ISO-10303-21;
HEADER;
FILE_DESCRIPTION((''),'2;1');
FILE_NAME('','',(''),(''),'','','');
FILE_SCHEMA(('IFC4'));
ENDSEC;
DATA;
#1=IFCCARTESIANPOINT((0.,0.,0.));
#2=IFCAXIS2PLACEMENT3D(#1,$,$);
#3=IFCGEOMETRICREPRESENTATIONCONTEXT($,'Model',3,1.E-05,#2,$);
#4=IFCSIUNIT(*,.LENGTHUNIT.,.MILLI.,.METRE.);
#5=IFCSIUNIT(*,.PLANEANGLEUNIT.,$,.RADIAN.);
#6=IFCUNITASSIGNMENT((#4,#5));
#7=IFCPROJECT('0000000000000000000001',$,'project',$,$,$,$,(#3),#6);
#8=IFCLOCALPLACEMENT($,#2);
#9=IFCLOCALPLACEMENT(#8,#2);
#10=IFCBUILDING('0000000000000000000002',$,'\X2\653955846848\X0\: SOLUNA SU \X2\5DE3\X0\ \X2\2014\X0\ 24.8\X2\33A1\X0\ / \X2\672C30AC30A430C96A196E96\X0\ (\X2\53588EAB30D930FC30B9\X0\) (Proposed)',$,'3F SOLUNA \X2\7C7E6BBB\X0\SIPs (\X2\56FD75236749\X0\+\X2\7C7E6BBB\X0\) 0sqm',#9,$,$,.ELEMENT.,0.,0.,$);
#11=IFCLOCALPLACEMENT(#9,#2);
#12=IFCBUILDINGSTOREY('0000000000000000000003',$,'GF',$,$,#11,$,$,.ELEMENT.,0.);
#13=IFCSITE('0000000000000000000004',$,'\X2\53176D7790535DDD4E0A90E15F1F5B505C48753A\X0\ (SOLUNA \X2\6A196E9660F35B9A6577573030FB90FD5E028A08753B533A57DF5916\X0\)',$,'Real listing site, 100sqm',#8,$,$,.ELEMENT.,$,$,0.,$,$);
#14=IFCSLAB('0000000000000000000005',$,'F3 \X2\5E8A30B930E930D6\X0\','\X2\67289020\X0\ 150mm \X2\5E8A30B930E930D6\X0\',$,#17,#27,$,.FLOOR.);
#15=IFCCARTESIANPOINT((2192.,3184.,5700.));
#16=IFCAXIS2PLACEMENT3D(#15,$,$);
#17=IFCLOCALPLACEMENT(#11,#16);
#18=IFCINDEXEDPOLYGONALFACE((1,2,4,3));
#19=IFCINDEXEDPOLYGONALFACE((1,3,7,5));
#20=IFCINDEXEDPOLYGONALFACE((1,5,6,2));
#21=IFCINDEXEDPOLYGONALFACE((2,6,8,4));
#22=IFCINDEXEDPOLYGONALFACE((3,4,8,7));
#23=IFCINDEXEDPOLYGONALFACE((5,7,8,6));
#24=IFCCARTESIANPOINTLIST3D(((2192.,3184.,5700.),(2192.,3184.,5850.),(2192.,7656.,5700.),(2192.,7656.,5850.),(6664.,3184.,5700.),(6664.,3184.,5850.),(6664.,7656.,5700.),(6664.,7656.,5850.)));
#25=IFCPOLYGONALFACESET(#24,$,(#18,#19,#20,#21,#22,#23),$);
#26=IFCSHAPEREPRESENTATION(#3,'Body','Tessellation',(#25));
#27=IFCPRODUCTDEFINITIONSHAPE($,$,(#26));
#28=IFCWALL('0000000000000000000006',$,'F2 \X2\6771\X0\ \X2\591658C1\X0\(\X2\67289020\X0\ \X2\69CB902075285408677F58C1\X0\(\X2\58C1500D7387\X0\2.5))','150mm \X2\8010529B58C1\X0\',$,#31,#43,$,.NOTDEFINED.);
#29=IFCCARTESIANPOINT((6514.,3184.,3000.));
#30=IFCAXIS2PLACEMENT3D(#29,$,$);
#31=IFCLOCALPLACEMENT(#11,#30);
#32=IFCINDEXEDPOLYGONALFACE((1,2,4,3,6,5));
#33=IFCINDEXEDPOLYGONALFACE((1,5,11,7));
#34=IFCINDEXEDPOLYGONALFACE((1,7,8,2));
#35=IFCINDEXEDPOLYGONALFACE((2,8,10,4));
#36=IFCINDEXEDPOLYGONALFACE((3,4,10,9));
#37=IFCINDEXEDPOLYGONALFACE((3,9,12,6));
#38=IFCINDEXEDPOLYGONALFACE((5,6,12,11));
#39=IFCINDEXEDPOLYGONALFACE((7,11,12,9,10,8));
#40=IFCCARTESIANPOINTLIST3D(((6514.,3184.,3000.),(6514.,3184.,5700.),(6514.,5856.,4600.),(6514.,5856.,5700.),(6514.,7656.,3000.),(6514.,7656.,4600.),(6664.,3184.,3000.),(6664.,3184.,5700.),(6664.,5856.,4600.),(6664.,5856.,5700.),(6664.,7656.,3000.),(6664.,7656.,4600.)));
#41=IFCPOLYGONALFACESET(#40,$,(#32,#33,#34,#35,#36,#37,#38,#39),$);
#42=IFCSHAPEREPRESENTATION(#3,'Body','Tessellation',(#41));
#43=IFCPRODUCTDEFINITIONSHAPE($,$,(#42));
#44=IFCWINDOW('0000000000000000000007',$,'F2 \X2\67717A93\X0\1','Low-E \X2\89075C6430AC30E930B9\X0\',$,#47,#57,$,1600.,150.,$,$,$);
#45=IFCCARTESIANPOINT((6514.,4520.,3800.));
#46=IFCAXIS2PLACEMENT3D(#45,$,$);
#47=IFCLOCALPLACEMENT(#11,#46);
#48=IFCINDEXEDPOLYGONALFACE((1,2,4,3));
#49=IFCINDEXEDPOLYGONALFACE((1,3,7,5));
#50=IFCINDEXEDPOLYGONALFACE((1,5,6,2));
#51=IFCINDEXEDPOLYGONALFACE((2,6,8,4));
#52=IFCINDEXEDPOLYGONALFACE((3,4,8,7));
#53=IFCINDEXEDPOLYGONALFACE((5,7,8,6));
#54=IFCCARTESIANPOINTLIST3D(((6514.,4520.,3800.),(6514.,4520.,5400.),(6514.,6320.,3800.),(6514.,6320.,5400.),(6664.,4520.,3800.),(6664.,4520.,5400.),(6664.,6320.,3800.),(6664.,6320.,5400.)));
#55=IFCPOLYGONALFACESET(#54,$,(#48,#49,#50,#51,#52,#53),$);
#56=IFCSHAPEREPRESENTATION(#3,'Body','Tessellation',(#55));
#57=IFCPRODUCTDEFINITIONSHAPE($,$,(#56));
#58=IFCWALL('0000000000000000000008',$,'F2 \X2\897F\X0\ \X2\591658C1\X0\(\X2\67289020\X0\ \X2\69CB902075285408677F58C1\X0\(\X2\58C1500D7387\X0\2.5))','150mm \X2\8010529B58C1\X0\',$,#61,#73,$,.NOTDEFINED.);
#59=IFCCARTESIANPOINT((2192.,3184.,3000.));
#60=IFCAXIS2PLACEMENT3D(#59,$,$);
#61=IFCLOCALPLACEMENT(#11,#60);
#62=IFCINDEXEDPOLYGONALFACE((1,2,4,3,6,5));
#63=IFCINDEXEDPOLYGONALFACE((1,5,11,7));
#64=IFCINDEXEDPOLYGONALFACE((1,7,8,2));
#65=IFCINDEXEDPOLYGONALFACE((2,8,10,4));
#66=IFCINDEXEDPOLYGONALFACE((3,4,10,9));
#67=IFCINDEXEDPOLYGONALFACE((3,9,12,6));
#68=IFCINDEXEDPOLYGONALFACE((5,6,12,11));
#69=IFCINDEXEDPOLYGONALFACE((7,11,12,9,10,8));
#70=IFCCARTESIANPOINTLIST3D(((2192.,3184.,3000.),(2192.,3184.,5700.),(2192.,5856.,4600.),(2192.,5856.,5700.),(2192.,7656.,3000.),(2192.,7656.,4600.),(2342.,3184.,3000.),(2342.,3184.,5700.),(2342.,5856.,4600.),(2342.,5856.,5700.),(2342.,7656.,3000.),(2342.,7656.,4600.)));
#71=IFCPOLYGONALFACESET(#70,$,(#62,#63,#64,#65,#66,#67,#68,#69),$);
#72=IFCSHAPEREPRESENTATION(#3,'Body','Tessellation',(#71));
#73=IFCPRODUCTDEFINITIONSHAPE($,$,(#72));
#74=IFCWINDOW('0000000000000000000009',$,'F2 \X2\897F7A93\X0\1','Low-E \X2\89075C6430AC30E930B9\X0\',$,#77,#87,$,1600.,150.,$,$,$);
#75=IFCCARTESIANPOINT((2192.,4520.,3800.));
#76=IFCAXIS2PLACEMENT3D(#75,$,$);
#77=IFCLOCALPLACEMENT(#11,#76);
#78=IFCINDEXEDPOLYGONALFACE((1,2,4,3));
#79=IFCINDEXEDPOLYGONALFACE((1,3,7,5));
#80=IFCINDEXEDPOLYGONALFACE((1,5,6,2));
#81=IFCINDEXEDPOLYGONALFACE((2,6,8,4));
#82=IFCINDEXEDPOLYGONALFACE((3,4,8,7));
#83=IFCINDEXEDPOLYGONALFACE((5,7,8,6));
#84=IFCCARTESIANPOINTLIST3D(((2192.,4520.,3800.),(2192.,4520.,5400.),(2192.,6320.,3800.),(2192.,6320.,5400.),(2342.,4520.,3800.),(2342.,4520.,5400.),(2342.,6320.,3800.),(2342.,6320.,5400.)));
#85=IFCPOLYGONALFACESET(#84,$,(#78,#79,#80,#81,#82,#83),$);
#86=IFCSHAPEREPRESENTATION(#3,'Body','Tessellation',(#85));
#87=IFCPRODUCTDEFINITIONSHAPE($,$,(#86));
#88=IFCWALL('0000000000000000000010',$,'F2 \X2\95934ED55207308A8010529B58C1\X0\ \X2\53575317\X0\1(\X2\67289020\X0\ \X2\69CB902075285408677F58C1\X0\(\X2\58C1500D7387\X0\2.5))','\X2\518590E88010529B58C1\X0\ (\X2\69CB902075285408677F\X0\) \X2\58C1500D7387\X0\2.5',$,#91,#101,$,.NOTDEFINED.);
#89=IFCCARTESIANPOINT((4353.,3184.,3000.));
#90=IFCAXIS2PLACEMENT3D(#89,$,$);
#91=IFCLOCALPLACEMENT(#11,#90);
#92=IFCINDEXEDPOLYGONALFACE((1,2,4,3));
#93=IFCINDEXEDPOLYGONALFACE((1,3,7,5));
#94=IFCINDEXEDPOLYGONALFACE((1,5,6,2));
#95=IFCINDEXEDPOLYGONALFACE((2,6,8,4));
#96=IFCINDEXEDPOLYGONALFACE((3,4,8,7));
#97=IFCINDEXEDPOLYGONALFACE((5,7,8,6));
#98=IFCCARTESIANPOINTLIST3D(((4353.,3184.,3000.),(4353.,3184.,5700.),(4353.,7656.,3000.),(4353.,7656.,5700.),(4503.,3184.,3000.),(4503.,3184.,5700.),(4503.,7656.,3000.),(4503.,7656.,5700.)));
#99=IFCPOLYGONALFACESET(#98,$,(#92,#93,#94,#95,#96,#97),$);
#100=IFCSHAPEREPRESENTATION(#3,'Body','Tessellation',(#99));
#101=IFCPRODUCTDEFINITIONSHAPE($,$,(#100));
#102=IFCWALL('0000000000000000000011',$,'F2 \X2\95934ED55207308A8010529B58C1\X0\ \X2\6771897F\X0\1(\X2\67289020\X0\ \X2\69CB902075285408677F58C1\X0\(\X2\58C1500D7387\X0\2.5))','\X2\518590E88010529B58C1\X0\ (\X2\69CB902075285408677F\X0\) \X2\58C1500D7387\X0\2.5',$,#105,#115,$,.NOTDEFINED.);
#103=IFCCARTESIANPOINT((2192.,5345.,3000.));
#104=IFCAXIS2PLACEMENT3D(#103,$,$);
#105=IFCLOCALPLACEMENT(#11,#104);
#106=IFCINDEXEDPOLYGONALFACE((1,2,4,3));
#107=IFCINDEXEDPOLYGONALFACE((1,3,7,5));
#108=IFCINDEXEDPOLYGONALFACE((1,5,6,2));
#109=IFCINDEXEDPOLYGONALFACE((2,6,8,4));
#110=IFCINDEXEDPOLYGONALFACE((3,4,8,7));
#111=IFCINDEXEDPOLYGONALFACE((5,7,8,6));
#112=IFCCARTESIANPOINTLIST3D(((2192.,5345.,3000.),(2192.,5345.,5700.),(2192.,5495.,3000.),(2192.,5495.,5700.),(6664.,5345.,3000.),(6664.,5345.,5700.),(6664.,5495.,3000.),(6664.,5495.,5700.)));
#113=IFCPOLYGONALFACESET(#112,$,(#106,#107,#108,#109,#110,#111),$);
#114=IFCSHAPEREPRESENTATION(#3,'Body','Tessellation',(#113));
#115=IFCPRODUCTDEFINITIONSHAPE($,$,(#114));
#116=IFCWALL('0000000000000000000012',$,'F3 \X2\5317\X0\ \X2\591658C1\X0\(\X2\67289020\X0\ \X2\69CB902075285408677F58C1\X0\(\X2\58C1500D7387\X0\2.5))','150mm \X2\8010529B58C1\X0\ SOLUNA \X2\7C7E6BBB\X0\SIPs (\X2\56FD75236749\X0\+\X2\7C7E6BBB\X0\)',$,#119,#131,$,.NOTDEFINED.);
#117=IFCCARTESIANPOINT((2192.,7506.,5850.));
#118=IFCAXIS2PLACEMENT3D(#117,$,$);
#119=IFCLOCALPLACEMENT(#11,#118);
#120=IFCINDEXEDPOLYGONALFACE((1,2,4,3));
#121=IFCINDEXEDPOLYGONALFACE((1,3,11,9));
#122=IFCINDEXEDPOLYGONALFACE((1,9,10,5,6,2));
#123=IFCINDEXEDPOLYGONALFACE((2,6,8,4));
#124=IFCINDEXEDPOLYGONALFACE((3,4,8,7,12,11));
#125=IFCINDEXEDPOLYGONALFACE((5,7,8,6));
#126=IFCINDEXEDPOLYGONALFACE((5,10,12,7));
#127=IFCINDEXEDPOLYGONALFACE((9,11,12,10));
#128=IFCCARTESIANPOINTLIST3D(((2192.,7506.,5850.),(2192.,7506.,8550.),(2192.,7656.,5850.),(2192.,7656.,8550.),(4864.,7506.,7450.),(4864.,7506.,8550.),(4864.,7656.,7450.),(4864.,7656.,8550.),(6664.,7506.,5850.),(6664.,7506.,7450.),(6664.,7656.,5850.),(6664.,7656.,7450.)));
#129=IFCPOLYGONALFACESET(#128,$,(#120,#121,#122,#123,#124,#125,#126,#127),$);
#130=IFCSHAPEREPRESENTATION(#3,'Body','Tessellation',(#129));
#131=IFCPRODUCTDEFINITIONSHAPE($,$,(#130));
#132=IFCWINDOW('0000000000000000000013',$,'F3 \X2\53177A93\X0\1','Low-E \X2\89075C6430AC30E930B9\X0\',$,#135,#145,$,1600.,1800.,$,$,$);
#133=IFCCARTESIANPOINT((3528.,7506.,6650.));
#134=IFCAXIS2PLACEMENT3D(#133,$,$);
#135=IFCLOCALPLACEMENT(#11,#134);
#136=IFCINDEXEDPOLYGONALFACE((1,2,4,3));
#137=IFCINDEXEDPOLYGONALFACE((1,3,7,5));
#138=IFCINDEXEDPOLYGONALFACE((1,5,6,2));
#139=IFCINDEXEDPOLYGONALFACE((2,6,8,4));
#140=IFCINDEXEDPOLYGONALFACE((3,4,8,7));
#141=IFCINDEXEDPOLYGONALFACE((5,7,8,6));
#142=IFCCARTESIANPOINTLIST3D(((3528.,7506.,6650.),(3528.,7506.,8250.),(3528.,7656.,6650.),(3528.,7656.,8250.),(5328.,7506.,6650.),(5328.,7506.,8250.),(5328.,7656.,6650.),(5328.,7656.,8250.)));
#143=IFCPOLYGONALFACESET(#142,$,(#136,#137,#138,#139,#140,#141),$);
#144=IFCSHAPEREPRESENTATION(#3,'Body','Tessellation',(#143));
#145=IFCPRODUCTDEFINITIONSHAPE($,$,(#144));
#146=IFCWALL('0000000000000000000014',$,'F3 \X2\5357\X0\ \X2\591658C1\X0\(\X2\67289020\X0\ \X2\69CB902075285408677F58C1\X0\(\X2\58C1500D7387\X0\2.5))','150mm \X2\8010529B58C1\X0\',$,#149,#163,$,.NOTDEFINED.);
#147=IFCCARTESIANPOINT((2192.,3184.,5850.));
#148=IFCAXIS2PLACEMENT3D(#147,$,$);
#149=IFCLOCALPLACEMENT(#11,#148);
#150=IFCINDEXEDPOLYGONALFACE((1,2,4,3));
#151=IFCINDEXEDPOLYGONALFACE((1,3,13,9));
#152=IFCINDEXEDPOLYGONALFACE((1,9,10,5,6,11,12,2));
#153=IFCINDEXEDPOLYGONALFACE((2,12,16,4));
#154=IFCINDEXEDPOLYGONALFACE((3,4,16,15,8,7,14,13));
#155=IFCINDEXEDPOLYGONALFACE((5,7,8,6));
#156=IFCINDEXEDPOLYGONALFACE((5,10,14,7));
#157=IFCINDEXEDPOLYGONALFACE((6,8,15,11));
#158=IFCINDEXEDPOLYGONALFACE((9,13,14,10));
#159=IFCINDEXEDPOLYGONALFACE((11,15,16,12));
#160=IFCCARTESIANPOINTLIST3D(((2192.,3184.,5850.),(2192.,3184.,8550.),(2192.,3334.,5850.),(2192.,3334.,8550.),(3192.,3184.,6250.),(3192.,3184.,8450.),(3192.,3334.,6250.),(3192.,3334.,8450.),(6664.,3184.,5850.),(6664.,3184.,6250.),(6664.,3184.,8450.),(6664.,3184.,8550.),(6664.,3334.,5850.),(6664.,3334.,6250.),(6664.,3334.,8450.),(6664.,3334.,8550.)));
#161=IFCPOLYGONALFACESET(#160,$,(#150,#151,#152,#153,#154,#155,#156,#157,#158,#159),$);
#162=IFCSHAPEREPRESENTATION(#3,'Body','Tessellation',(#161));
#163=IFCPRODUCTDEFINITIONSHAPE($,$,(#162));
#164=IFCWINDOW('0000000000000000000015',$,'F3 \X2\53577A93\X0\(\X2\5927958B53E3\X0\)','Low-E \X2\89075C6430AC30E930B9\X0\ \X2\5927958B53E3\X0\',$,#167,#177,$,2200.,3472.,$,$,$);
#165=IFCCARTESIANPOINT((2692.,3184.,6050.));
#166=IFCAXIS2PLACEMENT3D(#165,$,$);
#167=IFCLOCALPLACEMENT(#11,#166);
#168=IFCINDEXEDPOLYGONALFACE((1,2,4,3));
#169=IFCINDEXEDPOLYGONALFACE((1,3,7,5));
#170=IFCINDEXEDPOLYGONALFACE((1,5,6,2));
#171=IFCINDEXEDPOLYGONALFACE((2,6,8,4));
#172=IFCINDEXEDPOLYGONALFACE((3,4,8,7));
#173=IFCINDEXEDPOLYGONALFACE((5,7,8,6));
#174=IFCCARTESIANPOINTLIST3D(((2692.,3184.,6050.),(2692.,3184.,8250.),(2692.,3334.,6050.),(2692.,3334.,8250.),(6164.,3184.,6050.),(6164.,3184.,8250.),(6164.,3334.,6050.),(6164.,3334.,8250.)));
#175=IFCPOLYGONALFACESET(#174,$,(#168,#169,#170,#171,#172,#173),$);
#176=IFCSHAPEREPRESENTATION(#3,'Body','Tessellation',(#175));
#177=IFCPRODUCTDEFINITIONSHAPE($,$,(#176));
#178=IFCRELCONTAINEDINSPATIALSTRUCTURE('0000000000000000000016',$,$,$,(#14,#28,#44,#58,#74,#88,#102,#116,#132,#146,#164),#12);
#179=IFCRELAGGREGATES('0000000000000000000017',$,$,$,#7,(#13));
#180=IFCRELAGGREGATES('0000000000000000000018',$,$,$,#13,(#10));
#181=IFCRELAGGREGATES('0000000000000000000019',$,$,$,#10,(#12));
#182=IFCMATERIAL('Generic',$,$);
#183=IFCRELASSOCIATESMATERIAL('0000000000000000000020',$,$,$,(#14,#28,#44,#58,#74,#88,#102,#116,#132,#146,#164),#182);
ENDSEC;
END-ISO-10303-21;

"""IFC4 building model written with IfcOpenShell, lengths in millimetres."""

from ifc_helpers import new_model, si_unit, frame, frame_2d, origin, place, context, project, spatial, rectangle, extrude, material, element, fill, save


model = new_model("IFC4")

# Units and contexts
model_context = context("Model", 3, precision=1e-05, world=origin())
ifc_project = project(units=[si_unit("LENGTHUNIT", "METRE", prefix="MILLI"), si_unit("PLANEANGLEUNIT", "RADIAN")], contexts=[model_context])

# Site, building, storey
site_placement = place(None, origin())
site = spatial("IfcSite", under=ifc_project, at=site_placement, Name="北海道川上郡弟子屈町 (SOLUNA 標準想定敷地・都市計画区域外)", ObjectType="Real listing site, 100sqm", CompositionType="ELEMENT", RefElevation=0.0)
building_placement = place(site_placement, origin())
building = spatial("IfcBuilding", under=site, at=building_placement, Name="改善案: SOLUNA SU 巣 — 24.8㎡ / 本ガイド標準 (単身ベース) (Proposed)", ObjectType="3F SOLUNA 籾殻SIPs (国産杉+籾殻) 0sqm", CompositionType="ELEMENT", ElevationOfRefHeight=0.0, ElevationOfTerrain=0.0)
storey_placement = place(building_placement, origin())
storey = spatial("IfcBuildingStorey", under=building, at=storey_placement, Name="GF", CompositionType="ELEMENT", Elevation=0.0)

# Slab
ifc_material_1 = material(Name="Generic")
slab_placement = place(storey_placement, frame((2192.0, 3184.0, 5700.0)))
element("IfcSlab", 1, at=slab_placement, inside=storey, material=ifc_material_1, Name="F3 床スラブ", Description="木造 150mm 床スラブ", PredefinedType="FLOOR", context=model_context, shape_type="SweptSolid", body=[
    extrude(rectangle(XDim=4472.0, YDim=4472.0, at=frame_2d((2236.0, 2236.0))), frame((2192.0, 3184.0, 5700.0)), (0.0, 0.0, 1.0), 150.0),
])

# Walls, openings, windows
wall_1_placement = place(storey_placement, frame((6514.0, 3184.0, 3000.0)))
wall_1 = element("IfcWall", 2, at=wall_1_placement, inside=storey, material=ifc_material_1, Name="F2 東 外壁(木造 構造用合板壁(壁倍率2.5))", Description="150mm 耐力壁", PredefinedType="NOTDEFINED", context=model_context, shape_type="SweptSolid", body=[
    extrude(rectangle(XDim=150.0, YDim=4472.0, at=frame_2d((75.0, 2236.0))), frame((6514.0, 3184.0, 3000.0)), (0.0, 0.0, 1.0), 2700.0),
])
opening_1_placement = place(storey_placement, frame((6514.0, 4520.0, 3800.0)))
opening_1 = element("IfcOpeningElement", 3, at=opening_1_placement, cuts=wall_1, PredefinedType="NOTDEFINED", context=model_context, shape_type="SweptSolid", body=[
    extrude(rectangle(XDim=150.0, YDim=1800.0, at=frame_2d((75.0, 900.0))), frame((6514.0, 4520.0, 3800.0)), (0.0, 0.0, 1.0), 1600.0),
])
window_1_placement = place(storey_placement, frame((6514.0, 4520.0, 3800.0)))
window_1 = element("IfcWindow", 4, at=window_1_placement, inside=storey, material=ifc_material_1, Name="F2 東窓1", Description="Low-E 複層ガラス", OverallHeight=1600.0, OverallWidth=150.0, context=model_context, shape_type="SweptSolid", body=[
    extrude(rectangle(XDim=150.0, YDim=1800.0, at=frame_2d((75.0, 900.0))), frame((6514.0, 4520.0, 3800.0)), (0.0, 0.0, 1.0), 1600.0),
])
fill(opening_1, window_1)
wall_2_placement = place(storey_placement, frame((2192.0, 3184.0, 3000.0)))
wall_2 = element("IfcWall", 5, at=wall_2_placement, inside=storey, material=ifc_material_1, Name="F2 西 外壁(木造 構造用合板壁(壁倍率2.5))", Description="150mm 耐力壁", PredefinedType="NOTDEFINED", context=model_context, shape_type="SweptSolid", body=[
    extrude(rectangle(XDim=150.0, YDim=4472.0, at=frame_2d((75.0, 2236.0))), frame((2192.0, 3184.0, 3000.0)), (0.0, 0.0, 1.0), 2700.0),
])
opening_2_placement = place(storey_placement, frame((2192.0, 4520.0, 3800.0)))
opening_2 = element("IfcOpeningElement", 6, at=opening_2_placement, cuts=wall_2, PredefinedType="NOTDEFINED", context=model_context, shape_type="SweptSolid", body=[
    extrude(rectangle(XDim=150.0, YDim=1800.0, at=frame_2d((75.0, 900.0))), frame((2192.0, 4520.0, 3800.0)), (0.0, 0.0, 1.0), 1600.0),
])
window_2_placement = place(storey_placement, frame((2192.0, 4520.0, 3800.0)))
window_2 = element("IfcWindow", 7, at=window_2_placement, inside=storey, material=ifc_material_1, Name="F2 西窓1", Description="Low-E 複層ガラス", OverallHeight=1600.0, OverallWidth=150.0, context=model_context, shape_type="SweptSolid", body=[
    extrude(rectangle(XDim=150.0, YDim=1800.0, at=frame_2d((75.0, 900.0))), frame((2192.0, 4520.0, 3800.0)), (0.0, 0.0, 1.0), 1600.0),
])
fill(opening_2, window_2)

# Walls
wall_3_placement = place(storey_placement, frame((4353.0, 3184.0, 3000.0)))
element("IfcWall", 8, at=wall_3_placement, inside=storey, material=ifc_material_1, Name="F2 間仕切り耐力壁 南北1(木造 構造用合板壁(壁倍率2.5))", Description="内部耐力壁 (構造用合板) 壁倍率2.5", PredefinedType="NOTDEFINED", context=model_context, shape_type="SweptSolid", body=[
    extrude(rectangle(XDim=150.0, YDim=4472.0, at=frame_2d((75.0, 2236.0))), frame((4353.0, 3184.0, 3000.0)), (0.0, 0.0, 1.0), 2700.0),
])
wall_4_placement = place(storey_placement, frame((2192.0, 5345.0, 3000.0)))
element("IfcWall", 9, at=wall_4_placement, inside=storey, material=ifc_material_1, Name="F2 間仕切り耐力壁 東西1(木造 構造用合板壁(壁倍率2.5))", Description="内部耐力壁 (構造用合板) 壁倍率2.5", PredefinedType="NOTDEFINED", context=model_context, shape_type="SweptSolid", body=[
    extrude(rectangle(XDim=4472.0, YDim=150.0, at=frame_2d((2236.0, 75.0))), frame((2192.0, 5345.0, 3000.0)), (0.0, 0.0, 1.0), 2700.0),
])

# Walls, openings, windows
wall_5_placement = place(storey_placement, frame((2192.0, 7506.0, 5850.0)))
wall_5 = element("IfcWall", 10, at=wall_5_placement, inside=storey, material=ifc_material_1, Name="F3 北 外壁(木造 構造用合板壁(壁倍率2.5))", Description="150mm 耐力壁 SOLUNA 籾殻SIPs (国産杉+籾殻)", PredefinedType="NOTDEFINED", context=model_context, shape_type="SweptSolid", body=[
    extrude(rectangle(XDim=4472.0, YDim=150.0, at=frame_2d((2236.0, 75.0))), frame((2192.0, 7506.0, 5850.0)), (0.0, 0.0, 1.0), 2700.0),
])
opening_3_placement = place(storey_placement, frame((3528.0, 7506.0, 6650.0)))
opening_3 = element("IfcOpeningElement", 11, at=opening_3_placement, cuts=wall_5, PredefinedType="NOTDEFINED", context=model_context, shape_type="SweptSolid", body=[
    extrude(rectangle(XDim=1800.0, YDim=150.0, at=frame_2d((900.0, 75.0))), frame((3528.0, 7506.0, 6650.0)), (0.0, 0.0, 1.0), 1600.0),
])
window_3_placement = place(storey_placement, frame((3528.0, 7506.0, 6650.0)))
window_3 = element("IfcWindow", 12, at=window_3_placement, inside=storey, material=ifc_material_1, Name="F3 北窓1", Description="Low-E 複層ガラス", OverallHeight=1600.0, OverallWidth=1800.0, context=model_context, shape_type="SweptSolid", body=[
    extrude(rectangle(XDim=1800.0, YDim=150.0, at=frame_2d((900.0, 75.0))), frame((3528.0, 7506.0, 6650.0)), (0.0, 0.0, 1.0), 1600.0),
])
fill(opening_3, window_3)
wall_6_placement = place(storey_placement, frame((2192.0, 3184.0, 5850.0)))
wall_6 = element("IfcWall", 13, at=wall_6_placement, inside=storey, material=ifc_material_1, Name="F3 南 外壁(木造 構造用合板壁(壁倍率2.5))", Description="150mm 耐力壁", PredefinedType="NOTDEFINED", context=model_context, shape_type="SweptSolid", body=[
    extrude(rectangle(XDim=4472.0, YDim=150.0, at=frame_2d((2236.0, 75.0))), frame((2192.0, 3184.0, 5850.0)), (0.0, 0.0, 1.0), 2700.0),
])
opening_4_placement = place(storey_placement, frame((2692.0, 3184.0, 6050.0)))
opening_4 = element("IfcOpeningElement", 14, at=opening_4_placement, cuts=wall_6, PredefinedType="NOTDEFINED", context=model_context, shape_type="SweptSolid", body=[
    extrude(rectangle(XDim=3472.0, YDim=150.0, at=frame_2d((1736.0, 75.0))), frame((2692.0, 3184.0, 6050.0)), (0.0, 0.0, 1.0), 2200.0),
])
window_4_placement = place(storey_placement, frame((2692.0, 3184.0, 6050.0)))
window_4 = element("IfcWindow", 15, at=window_4_placement, inside=storey, material=ifc_material_1, Name="F3 南窓(大開口)", Description="Low-E 複層ガラス 大開口", OverallHeight=2200.0, OverallWidth=3472.0, context=model_context, shape_type="SweptSolid", body=[
    extrude(rectangle(XDim=3472.0, YDim=150.0, at=frame_2d((1736.0, 75.0))), frame((2692.0, 3184.0, 6050.0)), (0.0, 0.0, 1.0), 2200.0),
])
fill(opening_4, window_4)

save(model, "model.ifc")
